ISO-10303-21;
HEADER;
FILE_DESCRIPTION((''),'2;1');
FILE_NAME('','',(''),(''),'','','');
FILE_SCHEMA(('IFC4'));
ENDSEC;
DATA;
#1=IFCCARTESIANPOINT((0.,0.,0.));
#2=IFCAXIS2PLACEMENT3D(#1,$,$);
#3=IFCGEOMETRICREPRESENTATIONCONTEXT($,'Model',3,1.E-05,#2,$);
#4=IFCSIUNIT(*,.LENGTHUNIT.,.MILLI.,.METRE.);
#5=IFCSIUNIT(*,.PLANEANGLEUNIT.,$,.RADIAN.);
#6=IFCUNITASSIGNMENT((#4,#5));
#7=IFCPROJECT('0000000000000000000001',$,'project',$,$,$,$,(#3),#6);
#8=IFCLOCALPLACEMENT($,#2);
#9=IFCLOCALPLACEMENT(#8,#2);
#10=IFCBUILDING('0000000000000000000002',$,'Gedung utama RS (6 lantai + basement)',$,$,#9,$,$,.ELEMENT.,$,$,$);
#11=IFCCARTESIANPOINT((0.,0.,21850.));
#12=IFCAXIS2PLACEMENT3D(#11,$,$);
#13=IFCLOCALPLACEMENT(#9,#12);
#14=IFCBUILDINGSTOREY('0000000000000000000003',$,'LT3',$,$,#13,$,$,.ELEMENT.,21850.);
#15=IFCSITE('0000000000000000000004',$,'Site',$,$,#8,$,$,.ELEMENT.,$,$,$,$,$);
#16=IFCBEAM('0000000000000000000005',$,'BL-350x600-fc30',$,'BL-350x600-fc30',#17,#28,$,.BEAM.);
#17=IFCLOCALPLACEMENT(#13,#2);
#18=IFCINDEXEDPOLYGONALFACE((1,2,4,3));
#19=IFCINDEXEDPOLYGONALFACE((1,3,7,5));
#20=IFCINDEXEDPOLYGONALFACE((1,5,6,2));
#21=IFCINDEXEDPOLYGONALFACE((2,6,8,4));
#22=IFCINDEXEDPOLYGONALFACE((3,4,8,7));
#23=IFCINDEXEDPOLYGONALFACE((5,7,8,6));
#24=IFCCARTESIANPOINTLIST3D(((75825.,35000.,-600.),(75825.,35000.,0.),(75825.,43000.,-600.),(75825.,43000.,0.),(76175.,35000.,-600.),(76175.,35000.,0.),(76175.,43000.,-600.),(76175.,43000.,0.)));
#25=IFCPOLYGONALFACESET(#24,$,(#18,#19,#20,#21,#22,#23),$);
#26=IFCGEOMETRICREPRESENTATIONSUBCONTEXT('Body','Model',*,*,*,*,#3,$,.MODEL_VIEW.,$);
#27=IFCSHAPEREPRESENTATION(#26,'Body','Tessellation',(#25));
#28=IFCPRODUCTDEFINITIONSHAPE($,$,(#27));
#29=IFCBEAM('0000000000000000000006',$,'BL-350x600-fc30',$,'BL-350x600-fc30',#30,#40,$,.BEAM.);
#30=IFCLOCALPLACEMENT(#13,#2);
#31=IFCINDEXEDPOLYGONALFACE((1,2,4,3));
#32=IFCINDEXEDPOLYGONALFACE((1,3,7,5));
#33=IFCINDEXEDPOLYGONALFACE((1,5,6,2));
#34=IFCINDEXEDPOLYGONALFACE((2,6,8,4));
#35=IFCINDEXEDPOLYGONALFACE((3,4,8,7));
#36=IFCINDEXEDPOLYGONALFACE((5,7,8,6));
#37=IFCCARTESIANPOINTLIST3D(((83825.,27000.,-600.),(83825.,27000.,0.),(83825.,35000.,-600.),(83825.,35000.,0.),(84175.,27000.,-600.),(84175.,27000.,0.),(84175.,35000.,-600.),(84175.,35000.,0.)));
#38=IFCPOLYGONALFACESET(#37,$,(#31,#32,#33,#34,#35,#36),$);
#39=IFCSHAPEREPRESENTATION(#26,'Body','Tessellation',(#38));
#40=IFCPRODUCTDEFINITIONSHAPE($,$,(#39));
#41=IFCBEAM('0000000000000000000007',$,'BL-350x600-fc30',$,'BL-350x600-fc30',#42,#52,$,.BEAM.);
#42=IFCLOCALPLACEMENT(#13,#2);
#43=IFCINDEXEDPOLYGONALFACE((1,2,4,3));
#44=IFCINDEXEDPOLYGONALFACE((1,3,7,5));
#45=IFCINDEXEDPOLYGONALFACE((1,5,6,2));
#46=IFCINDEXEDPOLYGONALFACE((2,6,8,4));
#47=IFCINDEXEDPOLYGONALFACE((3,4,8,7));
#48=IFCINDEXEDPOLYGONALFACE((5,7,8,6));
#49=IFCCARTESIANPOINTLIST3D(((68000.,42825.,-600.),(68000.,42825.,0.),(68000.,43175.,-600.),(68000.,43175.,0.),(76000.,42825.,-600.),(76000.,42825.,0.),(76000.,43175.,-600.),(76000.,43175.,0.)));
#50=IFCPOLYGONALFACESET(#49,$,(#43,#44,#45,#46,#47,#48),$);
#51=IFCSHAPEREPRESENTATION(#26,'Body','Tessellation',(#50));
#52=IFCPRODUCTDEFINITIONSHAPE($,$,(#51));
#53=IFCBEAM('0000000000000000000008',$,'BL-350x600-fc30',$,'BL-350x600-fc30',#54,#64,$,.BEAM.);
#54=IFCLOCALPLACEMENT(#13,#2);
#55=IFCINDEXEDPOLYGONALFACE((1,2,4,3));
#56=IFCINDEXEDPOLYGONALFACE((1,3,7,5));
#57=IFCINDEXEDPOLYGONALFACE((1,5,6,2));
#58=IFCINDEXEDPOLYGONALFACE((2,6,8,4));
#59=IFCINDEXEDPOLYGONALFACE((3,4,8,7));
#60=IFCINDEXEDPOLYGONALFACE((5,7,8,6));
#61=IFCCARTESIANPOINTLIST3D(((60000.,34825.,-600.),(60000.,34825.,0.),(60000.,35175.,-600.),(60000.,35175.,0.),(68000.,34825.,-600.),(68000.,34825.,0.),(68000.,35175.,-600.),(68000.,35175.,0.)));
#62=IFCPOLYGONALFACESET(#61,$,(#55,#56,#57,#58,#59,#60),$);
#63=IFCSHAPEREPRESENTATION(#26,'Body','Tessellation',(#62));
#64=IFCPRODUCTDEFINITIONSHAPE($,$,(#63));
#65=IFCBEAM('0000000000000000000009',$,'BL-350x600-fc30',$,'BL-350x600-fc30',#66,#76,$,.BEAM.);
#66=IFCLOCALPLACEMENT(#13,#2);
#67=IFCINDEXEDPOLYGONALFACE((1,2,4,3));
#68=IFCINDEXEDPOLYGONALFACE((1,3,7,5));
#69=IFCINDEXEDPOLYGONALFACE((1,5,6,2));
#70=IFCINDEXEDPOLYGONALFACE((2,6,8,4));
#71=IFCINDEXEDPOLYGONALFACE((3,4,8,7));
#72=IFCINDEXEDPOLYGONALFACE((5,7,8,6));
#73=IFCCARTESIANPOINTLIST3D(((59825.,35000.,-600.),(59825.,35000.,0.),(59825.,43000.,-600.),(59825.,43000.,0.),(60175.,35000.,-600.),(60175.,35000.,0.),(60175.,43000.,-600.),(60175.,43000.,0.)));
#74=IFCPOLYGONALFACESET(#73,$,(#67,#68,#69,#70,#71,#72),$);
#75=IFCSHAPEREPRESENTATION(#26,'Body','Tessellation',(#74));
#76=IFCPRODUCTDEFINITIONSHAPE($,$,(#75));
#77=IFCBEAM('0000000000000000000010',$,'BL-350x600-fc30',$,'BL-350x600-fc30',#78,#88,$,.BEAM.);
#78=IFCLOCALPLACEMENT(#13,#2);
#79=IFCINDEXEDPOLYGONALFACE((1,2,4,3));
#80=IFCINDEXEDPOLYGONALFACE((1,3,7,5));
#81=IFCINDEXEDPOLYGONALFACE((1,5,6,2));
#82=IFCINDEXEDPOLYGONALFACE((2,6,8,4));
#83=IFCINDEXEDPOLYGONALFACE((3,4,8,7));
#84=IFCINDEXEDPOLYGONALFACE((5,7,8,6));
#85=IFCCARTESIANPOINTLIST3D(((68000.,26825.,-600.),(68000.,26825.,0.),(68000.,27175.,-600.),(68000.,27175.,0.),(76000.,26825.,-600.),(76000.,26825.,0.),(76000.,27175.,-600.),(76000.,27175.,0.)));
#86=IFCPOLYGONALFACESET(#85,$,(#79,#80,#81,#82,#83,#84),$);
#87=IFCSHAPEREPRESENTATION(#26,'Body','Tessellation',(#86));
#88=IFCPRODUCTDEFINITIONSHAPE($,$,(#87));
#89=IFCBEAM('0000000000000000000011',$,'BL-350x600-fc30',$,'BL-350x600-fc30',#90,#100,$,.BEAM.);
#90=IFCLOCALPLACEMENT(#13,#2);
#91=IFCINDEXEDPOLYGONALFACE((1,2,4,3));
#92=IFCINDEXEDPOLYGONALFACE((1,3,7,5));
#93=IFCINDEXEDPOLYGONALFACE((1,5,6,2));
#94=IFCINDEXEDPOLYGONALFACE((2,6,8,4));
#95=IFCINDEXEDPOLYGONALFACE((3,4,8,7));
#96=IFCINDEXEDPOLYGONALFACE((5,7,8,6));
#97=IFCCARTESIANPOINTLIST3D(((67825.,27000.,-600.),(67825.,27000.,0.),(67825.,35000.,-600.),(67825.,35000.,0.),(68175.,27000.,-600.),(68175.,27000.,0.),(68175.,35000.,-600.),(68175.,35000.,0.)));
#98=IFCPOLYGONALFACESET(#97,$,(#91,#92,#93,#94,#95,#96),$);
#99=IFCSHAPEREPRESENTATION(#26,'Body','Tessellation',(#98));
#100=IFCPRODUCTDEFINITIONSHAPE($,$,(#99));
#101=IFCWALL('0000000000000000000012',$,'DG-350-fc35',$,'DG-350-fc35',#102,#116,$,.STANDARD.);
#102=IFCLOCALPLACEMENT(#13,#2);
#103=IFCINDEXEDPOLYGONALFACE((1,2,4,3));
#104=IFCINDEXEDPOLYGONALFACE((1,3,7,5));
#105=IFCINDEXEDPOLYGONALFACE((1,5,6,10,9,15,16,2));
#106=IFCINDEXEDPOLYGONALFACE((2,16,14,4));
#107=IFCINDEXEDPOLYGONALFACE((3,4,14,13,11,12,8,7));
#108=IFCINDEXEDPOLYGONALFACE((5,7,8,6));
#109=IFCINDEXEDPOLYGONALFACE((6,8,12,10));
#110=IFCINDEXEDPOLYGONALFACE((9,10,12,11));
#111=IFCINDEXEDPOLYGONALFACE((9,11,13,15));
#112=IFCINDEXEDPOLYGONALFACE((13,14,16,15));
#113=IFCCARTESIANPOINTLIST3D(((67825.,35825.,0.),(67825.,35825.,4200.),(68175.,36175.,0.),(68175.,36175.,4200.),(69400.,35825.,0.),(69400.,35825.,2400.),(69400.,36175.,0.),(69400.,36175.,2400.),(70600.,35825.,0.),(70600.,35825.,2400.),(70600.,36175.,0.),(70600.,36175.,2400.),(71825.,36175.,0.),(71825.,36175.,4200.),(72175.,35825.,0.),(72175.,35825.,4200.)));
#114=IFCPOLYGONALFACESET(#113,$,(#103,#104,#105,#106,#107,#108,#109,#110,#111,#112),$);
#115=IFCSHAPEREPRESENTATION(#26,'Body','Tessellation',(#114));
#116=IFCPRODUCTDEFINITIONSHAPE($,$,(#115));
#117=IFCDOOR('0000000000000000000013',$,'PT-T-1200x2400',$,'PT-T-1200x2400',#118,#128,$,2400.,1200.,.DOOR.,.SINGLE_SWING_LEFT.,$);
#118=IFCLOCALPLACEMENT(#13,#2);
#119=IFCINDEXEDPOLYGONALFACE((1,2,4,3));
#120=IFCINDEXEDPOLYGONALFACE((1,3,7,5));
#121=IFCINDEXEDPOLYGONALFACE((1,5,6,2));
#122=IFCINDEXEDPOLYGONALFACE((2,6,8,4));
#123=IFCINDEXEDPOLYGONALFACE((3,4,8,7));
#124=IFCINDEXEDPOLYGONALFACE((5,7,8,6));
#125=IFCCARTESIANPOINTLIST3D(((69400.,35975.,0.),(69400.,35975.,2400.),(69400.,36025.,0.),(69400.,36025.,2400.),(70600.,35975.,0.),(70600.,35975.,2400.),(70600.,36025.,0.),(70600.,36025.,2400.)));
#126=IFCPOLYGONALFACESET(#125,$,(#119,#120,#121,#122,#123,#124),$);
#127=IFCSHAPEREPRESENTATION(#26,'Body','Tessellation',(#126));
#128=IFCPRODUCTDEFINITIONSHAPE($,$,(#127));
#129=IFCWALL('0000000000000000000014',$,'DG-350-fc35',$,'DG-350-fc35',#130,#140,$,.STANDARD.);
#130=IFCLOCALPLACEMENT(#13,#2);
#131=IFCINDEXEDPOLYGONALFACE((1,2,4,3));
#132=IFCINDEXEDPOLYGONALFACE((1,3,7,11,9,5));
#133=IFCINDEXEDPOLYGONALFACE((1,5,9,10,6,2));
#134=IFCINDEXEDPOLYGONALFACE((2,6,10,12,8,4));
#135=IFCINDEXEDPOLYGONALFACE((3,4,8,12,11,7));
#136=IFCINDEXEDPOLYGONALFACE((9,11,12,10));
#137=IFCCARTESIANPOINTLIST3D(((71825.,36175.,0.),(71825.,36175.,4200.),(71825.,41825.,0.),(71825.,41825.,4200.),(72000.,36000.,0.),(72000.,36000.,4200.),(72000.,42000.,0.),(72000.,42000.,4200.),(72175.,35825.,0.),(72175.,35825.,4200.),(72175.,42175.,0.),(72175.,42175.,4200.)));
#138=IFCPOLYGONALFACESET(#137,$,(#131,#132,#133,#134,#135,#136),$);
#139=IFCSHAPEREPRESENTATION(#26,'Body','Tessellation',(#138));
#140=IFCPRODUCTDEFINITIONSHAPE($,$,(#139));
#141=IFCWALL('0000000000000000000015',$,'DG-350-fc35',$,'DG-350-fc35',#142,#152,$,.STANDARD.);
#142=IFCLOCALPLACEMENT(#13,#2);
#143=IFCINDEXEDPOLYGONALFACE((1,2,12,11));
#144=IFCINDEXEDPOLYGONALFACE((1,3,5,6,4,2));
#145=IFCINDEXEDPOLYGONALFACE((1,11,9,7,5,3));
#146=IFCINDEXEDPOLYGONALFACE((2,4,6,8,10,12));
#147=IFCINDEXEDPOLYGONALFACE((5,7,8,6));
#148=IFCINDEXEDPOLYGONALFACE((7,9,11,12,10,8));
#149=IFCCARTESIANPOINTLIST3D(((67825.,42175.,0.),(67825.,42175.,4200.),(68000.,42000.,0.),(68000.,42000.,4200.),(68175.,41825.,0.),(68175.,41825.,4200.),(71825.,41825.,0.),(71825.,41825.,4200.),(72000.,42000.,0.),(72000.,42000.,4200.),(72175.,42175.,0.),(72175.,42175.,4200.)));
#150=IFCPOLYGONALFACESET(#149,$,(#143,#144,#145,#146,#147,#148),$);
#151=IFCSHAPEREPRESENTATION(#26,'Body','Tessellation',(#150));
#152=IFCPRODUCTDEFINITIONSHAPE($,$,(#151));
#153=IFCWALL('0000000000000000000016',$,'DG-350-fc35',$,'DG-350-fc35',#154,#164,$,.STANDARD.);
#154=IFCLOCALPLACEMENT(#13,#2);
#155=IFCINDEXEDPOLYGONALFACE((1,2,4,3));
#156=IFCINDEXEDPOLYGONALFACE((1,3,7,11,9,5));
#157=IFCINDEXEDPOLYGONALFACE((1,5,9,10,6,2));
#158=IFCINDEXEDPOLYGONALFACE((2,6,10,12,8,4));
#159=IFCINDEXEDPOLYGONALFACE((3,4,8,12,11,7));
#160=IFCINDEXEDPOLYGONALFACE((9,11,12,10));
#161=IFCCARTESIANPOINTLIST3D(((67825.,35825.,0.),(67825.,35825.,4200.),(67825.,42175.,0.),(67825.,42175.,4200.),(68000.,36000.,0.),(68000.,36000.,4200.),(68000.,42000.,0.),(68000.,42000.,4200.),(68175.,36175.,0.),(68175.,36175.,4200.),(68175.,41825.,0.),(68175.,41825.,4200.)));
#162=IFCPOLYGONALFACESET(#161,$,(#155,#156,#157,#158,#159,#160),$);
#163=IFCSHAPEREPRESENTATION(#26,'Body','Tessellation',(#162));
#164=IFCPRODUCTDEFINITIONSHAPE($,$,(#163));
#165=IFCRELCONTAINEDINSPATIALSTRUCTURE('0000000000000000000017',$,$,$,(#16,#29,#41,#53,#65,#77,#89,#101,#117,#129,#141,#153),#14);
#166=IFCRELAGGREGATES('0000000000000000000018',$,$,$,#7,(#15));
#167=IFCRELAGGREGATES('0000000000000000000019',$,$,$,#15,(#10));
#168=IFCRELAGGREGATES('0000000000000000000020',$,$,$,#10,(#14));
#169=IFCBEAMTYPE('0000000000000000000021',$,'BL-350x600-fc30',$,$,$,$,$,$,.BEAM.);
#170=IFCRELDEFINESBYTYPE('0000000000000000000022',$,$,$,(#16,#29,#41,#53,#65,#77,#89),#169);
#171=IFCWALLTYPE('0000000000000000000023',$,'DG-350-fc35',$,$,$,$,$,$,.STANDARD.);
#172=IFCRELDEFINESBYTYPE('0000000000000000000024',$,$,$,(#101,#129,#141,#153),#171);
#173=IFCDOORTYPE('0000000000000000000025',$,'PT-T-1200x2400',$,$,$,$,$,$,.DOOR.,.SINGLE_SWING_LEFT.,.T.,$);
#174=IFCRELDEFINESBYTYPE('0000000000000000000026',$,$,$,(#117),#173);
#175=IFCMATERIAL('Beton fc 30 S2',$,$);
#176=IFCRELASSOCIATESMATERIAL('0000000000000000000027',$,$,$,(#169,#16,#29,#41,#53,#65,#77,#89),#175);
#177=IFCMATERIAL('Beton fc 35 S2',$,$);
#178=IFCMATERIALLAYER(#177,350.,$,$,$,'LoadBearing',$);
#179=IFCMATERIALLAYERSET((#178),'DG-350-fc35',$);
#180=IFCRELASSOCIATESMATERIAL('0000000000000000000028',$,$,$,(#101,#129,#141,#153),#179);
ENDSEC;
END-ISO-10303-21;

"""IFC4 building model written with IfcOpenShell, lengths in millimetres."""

from ifc_helpers import new_model, si_unit, frame, frame_2d, origin, origin_2d, place, context, subcontext, project, spatial, polyline, rectangle, outline, extrude, material, layer, layer_set, layer_usage, material_profile, profile_set, profile_usage, type_object, element, fill, save


model = new_model("IFC4")

# Units and contexts
model_context = context("Model", 3, precision=1e-05, world=origin())
body_context = subcontext(model_context, "Body", "Model", "MODEL_VIEW")
ifc_project = project(units=[si_unit("LENGTHUNIT", "METRE", prefix="MILLI"), si_unit("PLANEANGLEUNIT", "RADIAN")], contexts=[model_context])

# Site, building, storey
site_placement = place(None, origin())
site = spatial("IfcSite", under=ifc_project, at=site_placement, Name="Site", CompositionType="ELEMENT")
building_placement = place(site_placement, origin())
building = spatial("IfcBuilding", under=site, at=building_placement, Name="Gedung utama RS (6 lantai + basement)", CompositionType="ELEMENT")
storey_placement = place(building_placement, frame((0.0, 0.0, 21850.0)))
storey = spatial("IfcBuildingStorey", under=building, at=storey_placement, Name="LT3", CompositionType="ELEMENT", Elevation=21850.0)

# Beams
ifc_material_1 = material(Name="Beton fc 30 S2")
ifc_material_profile_1 = material_profile(ifc_material_1, rectangle(XDim=350.0, YDim=600.0, at=origin_2d()), Name="BL-350x600-fc30")
ifc_profile_set_1 = profile_set([ifc_material_profile_1], Name="BL-350x600-fc30")
ifc_profile_usage_1 = profile_usage(ifc_profile_set_1, cardinal=8)
beam_type = type_object("IfcBeamType", Name="BL-350x600-fc30", PredefinedType="BEAM", material=ifc_profile_set_1)
for number, where, name in (
    (1, (76000.0, 35000.0, -300.0), "BL-350x600-fc30"),
    (2, (84000.0, 27000.0, -300.0), "BL-350x600-fc30"),
):
    element("IfcBeam", number, at=place(storey_placement, frame(where)), inside=storey, type_object=beam_type, material=ifc_profile_usage_1, Name=name, ObjectType="BL-350x600-fc30", PredefinedType="BEAM", context=body_context, shape_type="SweptSolid", body=[
        extrude(rectangle(XDim=350.0, YDim=600.0, at=origin_2d()), frame((0.0, 0.0, 0.0), z_axis=(0.0, 1.0, 0.0), x_axis=(-1.0, 0.0, 0.0)), (0.0, 0.0, 1.0), 8000.0),
    ])
for number, where, name in (
    (3, (68000.0, 43000.0, -300.0), "BL-350x600-fc30"),
    (4, (60000.0, 35000.0, -300.0), "BL-350x600-fc30"),
):
    element("IfcBeam", number, at=place(storey_placement, frame(where)), inside=storey, type_object=beam_type, material=ifc_profile_usage_1, Name=name, ObjectType="BL-350x600-fc30", PredefinedType="BEAM", context=body_context, shape_type="SweptSolid", body=[
        extrude(rectangle(XDim=350.0, YDim=600.0, at=origin_2d()), frame((0.0, 0.0, 0.0), z_axis=(1.0, 0.0, 0.0), x_axis=(0.0, 1.0, 0.0)), (0.0, 0.0, 1.0), 8000.0),
    ])
beam_1_placement = place(storey_placement, frame((60000.0, 35000.0, -300.0)))
element("IfcBeam", 5, at=beam_1_placement, inside=storey, type_object=beam_type, material=ifc_profile_usage_1, Name="BL-350x600-fc30", ObjectType="BL-350x600-fc30", PredefinedType="BEAM", context=body_context, shape_type="SweptSolid", body=[
    extrude(rectangle(XDim=350.0, YDim=600.0, at=origin_2d()), frame((0.0, 0.0, 0.0), z_axis=(0.0, 1.0, 0.0), x_axis=(-1.0, 0.0, 0.0)), (0.0, 0.0, 1.0), 8000.0),
])
beam_2_placement = place(storey_placement, frame((68000.0, 27000.0, -300.0)))
element("IfcBeam", 6, at=beam_2_placement, inside=storey, type_object=beam_type, material=ifc_profile_usage_1, Name="BL-350x600-fc30", ObjectType="BL-350x600-fc30", PredefinedType="BEAM", context=body_context, shape_type="SweptSolid", body=[
    extrude(rectangle(XDim=350.0, YDim=600.0, at=origin_2d()), frame((0.0, 0.0, 0.0), z_axis=(1.0, 0.0, 0.0), x_axis=(0.0, 1.0, 0.0)), (0.0, 0.0, 1.0), 8000.0),
])
beam_3_placement = place(storey_placement, frame((68000.0, 27000.0, -300.0)))
element("IfcBeam", 7, at=beam_3_placement, inside=storey, type_object=beam_type, material=ifc_profile_usage_1, Name="BL-350x600-fc30", ObjectType="BL-350x600-fc30", PredefinedType="BEAM", context=body_context, shape_type="SweptSolid", body=[
    extrude(rectangle(XDim=350.0, YDim=600.0, at=origin_2d()), frame((0.0, 0.0, 0.0), z_axis=(0.0, 1.0, 0.0), x_axis=(-1.0, 0.0, 0.0)), (0.0, 0.0, 1.0), 8000.0),
])

# Wall, opening, door
ifc_material_2 = material(Name="Beton fc 35 S2")
ifc_layer = layer(ifc_material_2, 350.0, Category="LoadBearing")
ifc_layer_set = layer_set([ifc_layer], Name="DG-350-fc35")
ifc_layer_usage = layer_usage(ifc_layer_set, "AXIS2", "NEGATIVE", 175.0)
wall_type = type_object("IfcWallType", Name="DG-350-fc35", PredefinedType="STANDARD")
wall_1_placement = place(storey_placement, frame((68000.0, 36000.0, 0.0), z_axis=(0.0, 0.0, 1.0), x_axis=(1.0, 0.0, 0.0)))
wall_1 = element("IfcWall", 8, at=wall_1_placement, inside=storey, type_object=wall_type, material=ifc_layer_usage, Name="DG-350-fc35", ObjectType="DG-350-fc35", PredefinedType="STANDARD", context=body_context, shape_type="SweptSolid", body=[
    extrude(outline(polyline([(-175.0, -175.0), (0.0, 0.0), (175.0, 175.0), (3825.0, 175.0), (4000.0, 0.0), (4175.0, -175.0), (-175.0, -175.0)])), origin(), (0.0, 0.0, 1.0), 4200.0),
])
opening_placement = place(wall_1_placement, frame((1400.0, 0.0, 0.0), z_axis=(0.0, 0.0, 1.0), x_axis=(1.0, 0.0, 0.0)))
opening = element("IfcOpeningElement", 9, at=opening_placement, cuts=wall_1, PredefinedType="OPENING", context=body_context, shape_type="SweptSolid", body=[
    extrude(rectangle(XDim=1200.0, YDim=370.0, at=frame_2d((600.0, 0.0))), origin(), (0.0, 0.0, 1.0), 2400.0),
])
door_type = type_object("IfcDoorType", Name="PT-T-1200x2400", OperationType="SINGLE_SWING_LEFT", ParameterTakesPrecedence=True, PredefinedType="DOOR")
door_placement = place(opening_placement, origin())
door = element("IfcDoor", 10, at=door_placement, inside=storey, type_object=door_type, Name="PT-T-1200x2400", ObjectType="PT-T-1200x2400", OperationType="SINGLE_SWING_LEFT", OverallHeight=2400.0, OverallWidth=1200.0, PredefinedType="DOOR", context=body_context, shape_type="SweptSolid", body=[
    extrude(rectangle(XDim=1200.0, YDim=50.0, at=frame_2d((600.0, 0.0))), origin(), (0.0, 0.0, 1.0), 2400.0),
])
fill(opening, door)

# Walls
wall_2_placement = place(storey_placement, frame((72000.0, 36000.0, 0.0), z_axis=(0.0, 0.0, 1.0), x_axis=(0.0, 1.0, 0.0)))
element("IfcWall", 11, at=wall_2_placement, inside=storey, type_object=wall_type, material=ifc_layer_usage, Name="DG-350-fc35", ObjectType="DG-350-fc35", PredefinedType="STANDARD", context=body_context, shape_type="SweptSolid", body=[
    extrude(outline(polyline([(-175.0, -175.0), (0.0, 0.0), (175.0, 175.0), (5825.0, 175.0), (6000.0, 0.0), (6175.0, -175.0), (-175.0, -175.0)])), origin(), (0.0, 0.0, 1.0), 4200.0),
])
wall_3_placement = place(storey_placement, frame((72000.0, 42000.0, 0.0), z_axis=(0.0, 0.0, 1.0), x_axis=(-1.0, 0.0, 0.0)))
element("IfcWall", 12, at=wall_3_placement, inside=storey, type_object=wall_type, material=ifc_layer_usage, Name="DG-350-fc35", ObjectType="DG-350-fc35", PredefinedType="STANDARD", context=body_context, shape_type="SweptSolid", body=[
    extrude(outline(polyline([(-175.0, -175.0), (0.0, 0.0), (175.0, 175.0), (3825.0, 175.0), (4000.0, 0.0), (4175.0, -175.0), (-175.0, -175.0)])), origin(), (0.0, 0.0, 1.0), 4200.0),
])
wall_4_placement = place(storey_placement, frame((68000.0, 42000.0, 0.0), z_axis=(0.0, 0.0, 1.0), x_axis=(0.0, -1.0, 0.0)))
element("IfcWall", 13, at=wall_4_placement, inside=storey, type_object=wall_type, material=ifc_layer_usage, Name="DG-350-fc35", ObjectType="DG-350-fc35", PredefinedType="STANDARD", context=body_context, shape_type="SweptSolid", body=[
    extrude(outline(polyline([(-175.0, -175.0), (0.0, 0.0), (175.0, 175.0), (5825.0, 175.0), (6000.0, 0.0), (6175.0, -175.0), (-175.0, -175.0)])), origin(), (0.0, 0.0, 1.0), 4200.0),
])

save(model, "model.ifc")
